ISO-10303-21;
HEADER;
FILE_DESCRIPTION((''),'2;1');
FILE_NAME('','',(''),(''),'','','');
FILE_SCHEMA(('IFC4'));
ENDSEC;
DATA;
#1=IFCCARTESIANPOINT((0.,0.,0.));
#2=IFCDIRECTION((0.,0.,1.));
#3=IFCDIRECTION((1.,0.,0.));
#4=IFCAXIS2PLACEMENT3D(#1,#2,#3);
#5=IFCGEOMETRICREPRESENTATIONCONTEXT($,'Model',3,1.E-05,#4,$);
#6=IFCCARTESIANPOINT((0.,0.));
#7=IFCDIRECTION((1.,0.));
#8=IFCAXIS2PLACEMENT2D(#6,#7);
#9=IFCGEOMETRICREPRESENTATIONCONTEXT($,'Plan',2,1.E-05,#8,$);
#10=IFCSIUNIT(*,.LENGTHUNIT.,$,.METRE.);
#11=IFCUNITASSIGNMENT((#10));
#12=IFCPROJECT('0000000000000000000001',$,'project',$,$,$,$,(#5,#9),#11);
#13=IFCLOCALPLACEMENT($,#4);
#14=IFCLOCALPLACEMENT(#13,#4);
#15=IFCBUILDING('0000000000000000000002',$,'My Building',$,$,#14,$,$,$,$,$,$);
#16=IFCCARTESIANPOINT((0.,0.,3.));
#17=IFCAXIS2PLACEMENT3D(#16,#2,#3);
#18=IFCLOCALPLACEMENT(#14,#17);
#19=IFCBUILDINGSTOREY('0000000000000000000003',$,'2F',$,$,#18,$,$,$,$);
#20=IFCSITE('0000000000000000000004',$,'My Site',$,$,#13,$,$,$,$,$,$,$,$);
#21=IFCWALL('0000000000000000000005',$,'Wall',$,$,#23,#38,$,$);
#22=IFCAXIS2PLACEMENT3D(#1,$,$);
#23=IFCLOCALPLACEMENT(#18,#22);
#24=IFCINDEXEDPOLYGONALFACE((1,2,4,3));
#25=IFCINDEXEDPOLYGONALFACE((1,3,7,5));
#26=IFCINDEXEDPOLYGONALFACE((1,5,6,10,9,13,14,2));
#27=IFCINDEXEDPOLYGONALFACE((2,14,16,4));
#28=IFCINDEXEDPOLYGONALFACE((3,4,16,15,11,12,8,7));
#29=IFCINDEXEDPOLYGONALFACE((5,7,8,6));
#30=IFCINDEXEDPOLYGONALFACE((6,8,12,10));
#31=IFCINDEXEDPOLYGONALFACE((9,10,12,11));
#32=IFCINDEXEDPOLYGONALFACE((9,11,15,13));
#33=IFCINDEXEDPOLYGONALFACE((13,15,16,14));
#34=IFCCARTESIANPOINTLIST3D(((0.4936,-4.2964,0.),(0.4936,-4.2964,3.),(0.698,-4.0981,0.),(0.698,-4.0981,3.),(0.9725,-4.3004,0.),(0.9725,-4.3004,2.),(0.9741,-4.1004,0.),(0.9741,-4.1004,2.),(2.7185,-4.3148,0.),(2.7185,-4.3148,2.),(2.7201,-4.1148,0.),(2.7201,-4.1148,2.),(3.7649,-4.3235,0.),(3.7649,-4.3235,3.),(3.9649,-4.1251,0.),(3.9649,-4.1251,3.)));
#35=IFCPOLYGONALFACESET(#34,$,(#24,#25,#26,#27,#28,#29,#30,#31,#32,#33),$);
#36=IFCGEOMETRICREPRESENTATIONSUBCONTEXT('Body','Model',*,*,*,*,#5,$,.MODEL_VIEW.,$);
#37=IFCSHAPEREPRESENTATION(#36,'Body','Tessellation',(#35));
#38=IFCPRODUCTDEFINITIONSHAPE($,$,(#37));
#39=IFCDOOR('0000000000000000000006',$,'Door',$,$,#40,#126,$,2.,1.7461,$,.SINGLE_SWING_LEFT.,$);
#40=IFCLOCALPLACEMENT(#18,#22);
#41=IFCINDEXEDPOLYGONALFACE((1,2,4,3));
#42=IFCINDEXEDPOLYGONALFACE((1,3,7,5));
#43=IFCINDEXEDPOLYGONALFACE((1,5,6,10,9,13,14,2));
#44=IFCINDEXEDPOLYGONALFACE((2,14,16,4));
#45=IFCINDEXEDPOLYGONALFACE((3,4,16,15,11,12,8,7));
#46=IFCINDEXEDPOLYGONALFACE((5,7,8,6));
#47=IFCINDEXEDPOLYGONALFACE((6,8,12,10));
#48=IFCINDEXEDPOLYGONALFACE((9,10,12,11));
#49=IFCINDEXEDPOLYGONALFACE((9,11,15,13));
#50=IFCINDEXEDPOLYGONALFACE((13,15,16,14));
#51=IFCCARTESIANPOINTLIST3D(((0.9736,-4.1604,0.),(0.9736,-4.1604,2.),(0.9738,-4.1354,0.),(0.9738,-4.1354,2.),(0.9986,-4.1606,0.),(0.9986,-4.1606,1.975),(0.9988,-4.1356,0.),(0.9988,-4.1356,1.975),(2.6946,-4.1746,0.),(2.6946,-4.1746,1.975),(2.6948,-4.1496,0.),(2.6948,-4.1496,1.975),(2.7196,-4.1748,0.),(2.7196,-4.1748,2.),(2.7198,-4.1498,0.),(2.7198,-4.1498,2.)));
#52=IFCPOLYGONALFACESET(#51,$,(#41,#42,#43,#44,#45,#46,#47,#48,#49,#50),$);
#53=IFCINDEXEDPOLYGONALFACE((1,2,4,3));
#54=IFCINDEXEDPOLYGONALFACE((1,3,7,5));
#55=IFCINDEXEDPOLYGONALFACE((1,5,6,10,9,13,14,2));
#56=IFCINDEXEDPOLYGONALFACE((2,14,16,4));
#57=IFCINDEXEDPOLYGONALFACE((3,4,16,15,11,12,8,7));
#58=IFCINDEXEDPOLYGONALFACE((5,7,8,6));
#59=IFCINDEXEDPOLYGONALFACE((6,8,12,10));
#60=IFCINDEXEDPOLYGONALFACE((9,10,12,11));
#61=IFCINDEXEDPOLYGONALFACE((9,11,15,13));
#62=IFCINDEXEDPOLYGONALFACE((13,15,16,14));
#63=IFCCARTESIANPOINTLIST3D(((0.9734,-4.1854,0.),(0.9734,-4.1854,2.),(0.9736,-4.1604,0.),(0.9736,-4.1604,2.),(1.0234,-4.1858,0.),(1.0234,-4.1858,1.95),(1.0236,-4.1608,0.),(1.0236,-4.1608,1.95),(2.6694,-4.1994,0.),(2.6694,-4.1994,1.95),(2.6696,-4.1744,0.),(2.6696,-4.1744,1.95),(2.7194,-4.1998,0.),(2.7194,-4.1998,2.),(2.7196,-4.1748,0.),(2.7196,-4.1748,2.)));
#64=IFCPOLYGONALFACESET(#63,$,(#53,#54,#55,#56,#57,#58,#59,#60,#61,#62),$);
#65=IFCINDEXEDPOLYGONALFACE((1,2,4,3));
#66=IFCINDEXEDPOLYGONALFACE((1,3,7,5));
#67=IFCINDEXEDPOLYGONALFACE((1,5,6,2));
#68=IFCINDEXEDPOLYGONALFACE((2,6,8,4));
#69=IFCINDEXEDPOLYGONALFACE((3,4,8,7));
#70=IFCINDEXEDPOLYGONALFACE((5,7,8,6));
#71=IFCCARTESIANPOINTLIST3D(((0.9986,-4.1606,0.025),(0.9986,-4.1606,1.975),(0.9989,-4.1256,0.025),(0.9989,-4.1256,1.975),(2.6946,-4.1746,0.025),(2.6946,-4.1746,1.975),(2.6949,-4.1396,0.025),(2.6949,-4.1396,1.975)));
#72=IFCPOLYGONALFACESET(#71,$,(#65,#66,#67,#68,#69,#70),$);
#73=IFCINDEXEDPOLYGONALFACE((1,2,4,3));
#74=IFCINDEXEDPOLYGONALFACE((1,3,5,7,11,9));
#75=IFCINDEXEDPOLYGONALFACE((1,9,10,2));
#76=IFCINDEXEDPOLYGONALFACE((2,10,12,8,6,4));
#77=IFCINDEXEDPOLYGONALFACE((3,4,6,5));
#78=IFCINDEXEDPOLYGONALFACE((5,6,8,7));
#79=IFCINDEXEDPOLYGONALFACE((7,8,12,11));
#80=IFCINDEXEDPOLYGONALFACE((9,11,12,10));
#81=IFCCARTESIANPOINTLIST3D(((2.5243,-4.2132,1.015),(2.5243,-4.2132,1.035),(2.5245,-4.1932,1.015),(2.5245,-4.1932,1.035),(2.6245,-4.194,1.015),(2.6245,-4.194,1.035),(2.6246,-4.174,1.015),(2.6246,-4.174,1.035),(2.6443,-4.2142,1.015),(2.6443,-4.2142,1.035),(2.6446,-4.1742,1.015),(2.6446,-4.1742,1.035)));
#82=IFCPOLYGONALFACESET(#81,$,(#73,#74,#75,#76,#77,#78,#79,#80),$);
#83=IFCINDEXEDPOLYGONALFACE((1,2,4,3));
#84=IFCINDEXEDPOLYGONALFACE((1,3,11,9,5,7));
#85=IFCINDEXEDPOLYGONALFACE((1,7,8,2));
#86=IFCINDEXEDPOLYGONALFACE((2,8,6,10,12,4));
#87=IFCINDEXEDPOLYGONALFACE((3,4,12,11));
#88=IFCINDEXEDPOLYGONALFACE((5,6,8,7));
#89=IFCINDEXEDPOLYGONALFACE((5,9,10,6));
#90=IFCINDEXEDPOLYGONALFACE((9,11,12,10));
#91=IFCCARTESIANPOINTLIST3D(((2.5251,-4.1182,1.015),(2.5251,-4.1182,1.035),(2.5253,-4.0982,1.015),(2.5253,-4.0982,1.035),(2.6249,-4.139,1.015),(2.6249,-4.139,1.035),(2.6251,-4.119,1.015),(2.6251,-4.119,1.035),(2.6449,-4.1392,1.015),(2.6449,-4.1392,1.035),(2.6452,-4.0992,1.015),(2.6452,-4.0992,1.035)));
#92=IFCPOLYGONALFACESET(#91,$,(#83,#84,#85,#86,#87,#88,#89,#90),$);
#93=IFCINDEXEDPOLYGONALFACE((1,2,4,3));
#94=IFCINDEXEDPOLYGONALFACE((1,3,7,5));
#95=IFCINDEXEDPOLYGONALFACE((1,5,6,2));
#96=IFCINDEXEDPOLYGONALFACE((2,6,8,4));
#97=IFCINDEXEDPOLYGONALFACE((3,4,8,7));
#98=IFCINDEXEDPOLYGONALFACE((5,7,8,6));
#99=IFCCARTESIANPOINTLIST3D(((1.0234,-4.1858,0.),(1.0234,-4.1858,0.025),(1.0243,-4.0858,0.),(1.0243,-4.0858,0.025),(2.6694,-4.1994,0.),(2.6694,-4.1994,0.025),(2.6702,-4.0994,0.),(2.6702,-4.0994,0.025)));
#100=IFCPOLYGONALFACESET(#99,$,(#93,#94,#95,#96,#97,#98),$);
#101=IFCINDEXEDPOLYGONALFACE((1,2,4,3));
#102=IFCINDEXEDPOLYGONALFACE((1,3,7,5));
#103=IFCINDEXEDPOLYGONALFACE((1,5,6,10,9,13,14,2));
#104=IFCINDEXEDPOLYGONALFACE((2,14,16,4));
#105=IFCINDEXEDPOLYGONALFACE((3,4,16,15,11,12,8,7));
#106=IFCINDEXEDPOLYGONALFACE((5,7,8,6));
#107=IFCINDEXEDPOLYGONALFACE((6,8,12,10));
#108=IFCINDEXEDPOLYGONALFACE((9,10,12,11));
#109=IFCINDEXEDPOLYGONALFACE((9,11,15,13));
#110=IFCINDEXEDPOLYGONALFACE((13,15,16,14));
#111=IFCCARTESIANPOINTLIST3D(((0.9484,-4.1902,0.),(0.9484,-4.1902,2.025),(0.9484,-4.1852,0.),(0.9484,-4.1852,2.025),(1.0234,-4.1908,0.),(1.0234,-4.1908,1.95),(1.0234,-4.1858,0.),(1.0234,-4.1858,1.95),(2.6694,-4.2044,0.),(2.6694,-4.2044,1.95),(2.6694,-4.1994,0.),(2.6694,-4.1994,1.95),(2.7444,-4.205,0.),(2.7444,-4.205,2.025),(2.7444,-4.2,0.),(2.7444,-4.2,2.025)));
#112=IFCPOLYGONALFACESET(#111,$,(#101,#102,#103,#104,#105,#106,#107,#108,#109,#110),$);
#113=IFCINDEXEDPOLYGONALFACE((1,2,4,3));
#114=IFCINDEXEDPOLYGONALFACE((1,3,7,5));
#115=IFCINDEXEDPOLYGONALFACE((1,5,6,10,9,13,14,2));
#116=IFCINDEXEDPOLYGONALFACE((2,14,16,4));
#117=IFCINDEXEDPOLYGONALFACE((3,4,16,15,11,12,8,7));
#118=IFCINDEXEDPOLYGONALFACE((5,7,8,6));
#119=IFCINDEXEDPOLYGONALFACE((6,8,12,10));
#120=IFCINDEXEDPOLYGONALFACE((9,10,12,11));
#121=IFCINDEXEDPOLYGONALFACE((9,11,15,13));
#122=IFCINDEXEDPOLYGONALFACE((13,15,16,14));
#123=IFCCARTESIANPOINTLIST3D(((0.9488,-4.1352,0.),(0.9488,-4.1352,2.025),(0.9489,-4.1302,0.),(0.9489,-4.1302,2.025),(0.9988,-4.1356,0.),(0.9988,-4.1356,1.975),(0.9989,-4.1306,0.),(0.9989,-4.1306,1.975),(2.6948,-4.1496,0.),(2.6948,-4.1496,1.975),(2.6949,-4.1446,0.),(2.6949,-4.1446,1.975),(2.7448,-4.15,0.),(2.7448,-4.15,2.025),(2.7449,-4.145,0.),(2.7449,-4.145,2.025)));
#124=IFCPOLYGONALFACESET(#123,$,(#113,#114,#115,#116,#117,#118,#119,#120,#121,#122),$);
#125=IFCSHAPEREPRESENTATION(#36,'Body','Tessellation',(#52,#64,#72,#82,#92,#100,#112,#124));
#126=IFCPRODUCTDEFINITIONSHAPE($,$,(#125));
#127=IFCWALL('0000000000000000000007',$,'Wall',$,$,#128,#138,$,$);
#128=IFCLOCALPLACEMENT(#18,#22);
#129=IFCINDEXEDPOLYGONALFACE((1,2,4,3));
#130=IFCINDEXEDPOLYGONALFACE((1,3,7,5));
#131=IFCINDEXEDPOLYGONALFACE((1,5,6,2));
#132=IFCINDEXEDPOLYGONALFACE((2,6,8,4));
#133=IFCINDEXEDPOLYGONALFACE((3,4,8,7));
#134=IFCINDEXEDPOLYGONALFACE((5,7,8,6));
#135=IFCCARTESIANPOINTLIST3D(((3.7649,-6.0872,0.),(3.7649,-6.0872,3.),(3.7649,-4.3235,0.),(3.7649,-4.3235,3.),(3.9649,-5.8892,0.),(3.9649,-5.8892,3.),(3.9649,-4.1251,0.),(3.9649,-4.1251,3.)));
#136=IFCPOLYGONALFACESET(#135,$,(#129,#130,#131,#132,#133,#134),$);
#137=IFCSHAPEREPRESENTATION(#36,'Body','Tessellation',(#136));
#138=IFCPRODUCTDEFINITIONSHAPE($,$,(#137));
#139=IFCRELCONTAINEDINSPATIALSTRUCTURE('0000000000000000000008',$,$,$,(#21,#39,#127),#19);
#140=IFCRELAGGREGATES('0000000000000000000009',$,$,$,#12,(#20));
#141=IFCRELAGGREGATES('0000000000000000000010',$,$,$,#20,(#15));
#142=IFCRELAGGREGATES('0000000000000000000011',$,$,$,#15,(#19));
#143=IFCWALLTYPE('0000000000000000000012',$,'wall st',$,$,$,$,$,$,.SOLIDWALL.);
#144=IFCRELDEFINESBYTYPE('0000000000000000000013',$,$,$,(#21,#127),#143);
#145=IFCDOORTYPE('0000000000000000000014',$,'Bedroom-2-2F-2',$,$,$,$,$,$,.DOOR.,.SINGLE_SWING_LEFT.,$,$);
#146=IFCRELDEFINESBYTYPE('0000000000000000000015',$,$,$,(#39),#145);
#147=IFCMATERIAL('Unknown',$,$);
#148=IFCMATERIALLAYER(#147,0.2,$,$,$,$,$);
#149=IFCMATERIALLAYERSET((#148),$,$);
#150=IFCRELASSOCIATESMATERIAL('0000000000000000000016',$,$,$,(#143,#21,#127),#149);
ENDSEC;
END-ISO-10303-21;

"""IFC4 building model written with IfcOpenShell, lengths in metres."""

from ifc_helpers import new_model, entity, si_unit, frame, origin_with_axes, origin_2d_with_axis, place, context, subcontext, project, spatial, line, indexed_curve, outline, extrude, shape, source, transform, mapped, material, layer, layer_set, layer_usage, type_object, type_shapes, element, fill, save


model = new_model("IFC4")

# Units and contexts
model_context = context("Model", 3, precision=1e-05, world=origin_with_axes())
plan_context = context("Plan", 2, precision=1e-05, world=origin_2d_with_axis())
body_context_1 = subcontext(model_context, "Body", "Model", "MODEL_VIEW")
body_context_2 = subcontext(plan_context, "Body", "Plan", "PLAN_VIEW")
ifc_project = project(units=[si_unit("LENGTHUNIT", "METRE")], contexts=[model_context, plan_context])

# Site, building, storey
site_placement = place(None, origin_with_axes())
site = spatial("IfcSite", under=ifc_project, at=site_placement, Name="My Site")
building_placement = place(site_placement, origin_with_axes())
building = spatial("IfcBuilding", under=site, at=building_placement, Name="My Building")
storey_placement = place(building_placement, frame((0.0, 0.0, 3.0), z_axis=(0.0, 0.0, 1.0), x_axis=(1.0, 0.0, 0.0)))
storey = spatial("IfcBuildingStorey", under=building, at=storey_placement, Name="2F")

# Shared definitions
ifc_material = material(Name="Unknown")

# Shared definitions
ifc_layer_1 = layer(ifc_material, 0.2)
ifc_layer_set_1 = layer_set([ifc_layer_1])
wall_type_1 = type_object("IfcWallType", Name="wall st", PredefinedType="SOLIDWALL", material=ifc_layer_set_1)

# Wall, opening, door
ifc_layer_usage_1 = layer_usage(ifc_layer_set_1, "AXIS2", "POSITIVE", 0.0)
wall_1_placement = place(storey_placement, frame((0.4936, -4.2964, 0.0), z_axis=(0.0, 0.0, 1.0), x_axis=(0.999966, -0.008264, 0.0)))
wall_1 = element("IfcWall", 1, at=wall_1_placement, inside=storey, type_object=wall_type_1, material=ifc_layer_usage_1, Name="Wall", context=body_context_1, shape_type="SweptSolid", body=[
    extrude(outline(indexed_curve([(0.0, 0.0), (0.2027, 0.2), (3.4697, 0.2), (3.2714, 0.0)], segments=[line(1, 2, 3, 4, 1)])), origin_with_axes(), (0.0, 0.0, 1.0), 3.0),
])
shared_shape_1 = source(origin_with_axes(), body_context_1, "Body", "SweptSolid", [
    extrude(outline(indexed_curve([(0.0, 0.0), (1.7461, 0.0), (1.7461, 2.0), (0.0, 2.0)], segments=[line(1, 2, 3, 4, 1)])), frame((0.0, -0.6, 0.0), z_axis=(0.0, -1.0, 0.0), x_axis=(1.0, 0.0, 0.0)), (0.0, 0.0, -1.0), 1.2),
])
opening_1_placement = place(wall_1_placement, frame((0.4789, 0.115, 0.0), z_axis=(0.0, 0.0, 1.0), x_axis=(1.0, 0.0, 0.0)))
opening_1 = element("IfcOpeningElement", 2, at=opening_1_placement, cuts=wall_1, PredefinedType="OPENING", context=body_context_1, shape_type="MappedRepresentation", body=[
    mapped(shared_shape_1, transform((0.0, 0.0, 0.0), x_axis=(1.0, 0.0, 0.0), y_axis=(0.0, 1.0, 0.0), z_axis=(0.0, 0.0, 1.0), scale=1.0)),
])
door_type_1 = type_object("IfcDoorType", Name="Bedroom-2-2F-2", OperationType="SINGLE_SWING_LEFT", PredefinedType="DOOR")
shared_shape_2 = source(origin_with_axes(), body_context_1, "Body", "SweptSolid", [
    extrude(outline(indexed_curve([(0.0, 0.0), (0.0, 2.0), (1.7461, 2.0), (1.7461, 0.0), (1.7211, 0.0), (1.7211, 1.975), (0.025, 1.975), (0.025, 0.0)], segments=[line(1, 2, 3, 4, 5, 6, 7, 8, 1)])), frame((0.0, 0.025, 0.0), z_axis=(0.0, -1.0, 0.0), x_axis=(1.0, 0.0, 0.0)), (0.0, 0.0, -1.0), 0.025),
    extrude(outline(indexed_curve([(0.0, 0.0), (0.0, 2.0), (1.7461, 2.0), (1.7461, 0.0), (1.6961, 0.0), (1.6961, 1.95), (0.05, 1.95), (0.05, 0.0)], segments=[line(1, 2, 3, 4, 5, 6, 7, 8, 1)])), frame((0.0, 0.0, 0.0), z_axis=(0.0, -1.0, 0.0), x_axis=(1.0, 0.0, 0.0)), (0.0, 0.0, -1.0), 0.025),
    extrude(outline(indexed_curve([(0.0, 0.0), (1.6961, 0.0), (1.6961, 0.035), (0.0, 0.035)], segments=[line(1, 2, 3, 4, 1)])), frame((0.025, 0.025, 0.025), z_axis=(0.0, 0.0, 1.0), x_axis=(1.0, 0.0, 0.0)), (0.0, 0.0, 1.0), 1.95),
    extrude(outline(indexed_curve([(0.0, 0.0), (0.0, -0.04), (-0.12, -0.04), (-0.12, -0.02), (-0.02, -0.02), (-0.02, 0.0)], segments=[line(1, 2, 3, 4, 5, 6, 1)])), frame((1.6711, 0.025, 1.015), z_axis=(0.0, 0.0, 1.0), x_axis=(1.0, 0.0, 0.0)), (0.0, 0.0, 1.0), 0.02),
    extrude(outline(indexed_curve([(0.0, 0.0), (0.0, 0.04), (-0.12, 0.04), (-0.12, 0.02), (-0.02, 0.02), (-0.02, 0.0)], segments=[line(1, 2, 3, 4, 5, 6, 1)])), frame((1.6711, 0.06, 1.015), z_axis=(0.0, 0.0, 1.0), x_axis=(1.0, 0.0, 0.0)), (0.0, 0.0, 1.0), 0.02),
    extrude(outline(indexed_curve([(0.0, 0.0), (1.6461, 0.0), (1.6461, 0.1), (0.0, 0.1)], segments=[line(1, 2, 3, 4, 1)])), frame((0.05, 0.0, 0.0), z_axis=(0.0, 0.0, 1.0), x_axis=(1.0, 0.0, 0.0)), (0.0, 0.0, 1.0), 0.025),
    extrude(outline(indexed_curve([(0.0, 0.0), (0.0, 2.025), (1.7961, 2.025), (1.7961, 0.0), (1.7211, 0.0), (1.7211, 1.95), (0.075, 1.95), (0.075, 0.0)], segments=[line(1, 2, 3, 4, 5, 6, 7, 8, 1)])), frame((-0.025, -0.005, 0.0), z_axis=(0.0, -1.0, 0.0), x_axis=(1.0, 0.0, 0.0)), (0.0, 0.0, -1.0), 0.005),
    extrude(outline(indexed_curve([(0.0, 0.0), (0.0, 2.025), (1.7961, 2.025), (1.7961, 0.0), (1.7461, 0.0), (1.7461, 1.975), (0.05, 1.975), (0.05, 0.0)], segments=[line(1, 2, 3, 4, 5, 6, 7, 8, 1)])), frame((-0.025, 0.05, 0.0), z_axis=(0.0, -1.0, 0.0), x_axis=(1.0, 0.0, 0.0)), (0.0, 0.0, -1.0), 0.005),
])
shared_shape_3 = source(origin_with_axes(), body_context_2, "Body", "Curve2D", [
    entity("IfcIndexedPolyCurve", entity("IfcCartesianPointList2D", [[0.0, 0.0], [0.0, 0.05], [0.025, 0.05], [0.025, 0.025], [0.05, 0.025], [0.05, 0.0]]), [entity("IfcLineIndex", [1, 2, 3, 4, 5, 6, 1])]),
    entity("IfcIndexedPolyCurve", entity("IfcCartesianPointList2D", [[1.7461, 0.0], [1.7461, 0.05], [1.7211, 0.05], [1.7211, 0.025], [1.6961, 0.025], [1.6961, 0.0]]), [entity("IfcLineIndex", [1, 2, 3, 4, 5, 6, 1])]),
    entity("IfcTrimmedCurve", entity("IfcEllipse", entity("IfcAxis2Placement2D", entity("IfcCartesianPoint", [0.06, 0.05]), entity("IfcDirection", [1.0, 0.0])), 1.6611, 1.6961), [entity("IfcCartesianPoint", [1.7211, 0.05])], [entity("IfcCartesianPoint", [0.06, 1.7461])], True, "CARTESIAN"),
    entity("IfcIndexedPolyCurve", entity("IfcCartesianPointList2D", [[0.025, 0.05], [0.06, 0.05], [0.06, 1.7461], [0.025, 1.7461]]), [entity("IfcLineIndex", [1, 2, 3, 4, 1])]),
])
type_shapes(door_type_1, [shared_shape_2, shared_shape_3])
door_1_placement = place(opening_1_placement, frame((0.0, 0.0, 0.0), z_axis=(0.0, 0.0, 1.0), x_axis=(1.0, 0.0, 0.0)))
door_1 = element("IfcDoor", 3, at=door_1_placement, inside=storey, type_object=door_type_1, Name="Door", OperationType="SINGLE_SWING_LEFT", OverallHeight=2.0, OverallWidth=1.7461, shapes=[
    shape(body_context_1, "Body", "MappedRepresentation", [mapped(shared_shape_2, transform((0.0, 0.0, 0.0), x_axis=(1.0, 0.0, 0.0), y_axis=(0.0, 1.0, 0.0), z_axis=(0.0, 0.0, 1.0), scale=1.0))]),
    shape(body_context_2, "Body", "MappedRepresentation", [mapped(shared_shape_3, transform((0.0, 0.0, 0.0), x_axis=(1.0, 0.0, 0.0), y_axis=(0.0, 1.0, 0.0), z_axis=(0.0, 0.0, 1.0), scale=1.0))]),
])
fill(opening_1, door_1)

# Wall
ifc_layer_usage_2 = layer_usage(ifc_layer_set_1, "AXIS2", "POSITIVE", 0.0)
wall_2_placement = place(storey_placement, frame((3.7649, -4.3235, 0.0), z_axis=(0.0, 0.0, 1.0), x_axis=(0.0, -1.0, 0.0)))
element("IfcWall", 4, at=wall_2_placement, inside=storey, type_object=wall_type_1, material=ifc_layer_usage_2, Name="Wall", context=body_context_1, shape_type="SweptSolid", body=[
    extrude(outline(indexed_curve([(0.0, 0.0), (-0.1984, 0.2), (1.5658, 0.2), (1.7637, 0.0)], segments=[line(1, 2, 3, 4, 1)])), origin_with_axes(), (0.0, 0.0, 1.0), 3.0),
])

save(model, "model.ifc")
